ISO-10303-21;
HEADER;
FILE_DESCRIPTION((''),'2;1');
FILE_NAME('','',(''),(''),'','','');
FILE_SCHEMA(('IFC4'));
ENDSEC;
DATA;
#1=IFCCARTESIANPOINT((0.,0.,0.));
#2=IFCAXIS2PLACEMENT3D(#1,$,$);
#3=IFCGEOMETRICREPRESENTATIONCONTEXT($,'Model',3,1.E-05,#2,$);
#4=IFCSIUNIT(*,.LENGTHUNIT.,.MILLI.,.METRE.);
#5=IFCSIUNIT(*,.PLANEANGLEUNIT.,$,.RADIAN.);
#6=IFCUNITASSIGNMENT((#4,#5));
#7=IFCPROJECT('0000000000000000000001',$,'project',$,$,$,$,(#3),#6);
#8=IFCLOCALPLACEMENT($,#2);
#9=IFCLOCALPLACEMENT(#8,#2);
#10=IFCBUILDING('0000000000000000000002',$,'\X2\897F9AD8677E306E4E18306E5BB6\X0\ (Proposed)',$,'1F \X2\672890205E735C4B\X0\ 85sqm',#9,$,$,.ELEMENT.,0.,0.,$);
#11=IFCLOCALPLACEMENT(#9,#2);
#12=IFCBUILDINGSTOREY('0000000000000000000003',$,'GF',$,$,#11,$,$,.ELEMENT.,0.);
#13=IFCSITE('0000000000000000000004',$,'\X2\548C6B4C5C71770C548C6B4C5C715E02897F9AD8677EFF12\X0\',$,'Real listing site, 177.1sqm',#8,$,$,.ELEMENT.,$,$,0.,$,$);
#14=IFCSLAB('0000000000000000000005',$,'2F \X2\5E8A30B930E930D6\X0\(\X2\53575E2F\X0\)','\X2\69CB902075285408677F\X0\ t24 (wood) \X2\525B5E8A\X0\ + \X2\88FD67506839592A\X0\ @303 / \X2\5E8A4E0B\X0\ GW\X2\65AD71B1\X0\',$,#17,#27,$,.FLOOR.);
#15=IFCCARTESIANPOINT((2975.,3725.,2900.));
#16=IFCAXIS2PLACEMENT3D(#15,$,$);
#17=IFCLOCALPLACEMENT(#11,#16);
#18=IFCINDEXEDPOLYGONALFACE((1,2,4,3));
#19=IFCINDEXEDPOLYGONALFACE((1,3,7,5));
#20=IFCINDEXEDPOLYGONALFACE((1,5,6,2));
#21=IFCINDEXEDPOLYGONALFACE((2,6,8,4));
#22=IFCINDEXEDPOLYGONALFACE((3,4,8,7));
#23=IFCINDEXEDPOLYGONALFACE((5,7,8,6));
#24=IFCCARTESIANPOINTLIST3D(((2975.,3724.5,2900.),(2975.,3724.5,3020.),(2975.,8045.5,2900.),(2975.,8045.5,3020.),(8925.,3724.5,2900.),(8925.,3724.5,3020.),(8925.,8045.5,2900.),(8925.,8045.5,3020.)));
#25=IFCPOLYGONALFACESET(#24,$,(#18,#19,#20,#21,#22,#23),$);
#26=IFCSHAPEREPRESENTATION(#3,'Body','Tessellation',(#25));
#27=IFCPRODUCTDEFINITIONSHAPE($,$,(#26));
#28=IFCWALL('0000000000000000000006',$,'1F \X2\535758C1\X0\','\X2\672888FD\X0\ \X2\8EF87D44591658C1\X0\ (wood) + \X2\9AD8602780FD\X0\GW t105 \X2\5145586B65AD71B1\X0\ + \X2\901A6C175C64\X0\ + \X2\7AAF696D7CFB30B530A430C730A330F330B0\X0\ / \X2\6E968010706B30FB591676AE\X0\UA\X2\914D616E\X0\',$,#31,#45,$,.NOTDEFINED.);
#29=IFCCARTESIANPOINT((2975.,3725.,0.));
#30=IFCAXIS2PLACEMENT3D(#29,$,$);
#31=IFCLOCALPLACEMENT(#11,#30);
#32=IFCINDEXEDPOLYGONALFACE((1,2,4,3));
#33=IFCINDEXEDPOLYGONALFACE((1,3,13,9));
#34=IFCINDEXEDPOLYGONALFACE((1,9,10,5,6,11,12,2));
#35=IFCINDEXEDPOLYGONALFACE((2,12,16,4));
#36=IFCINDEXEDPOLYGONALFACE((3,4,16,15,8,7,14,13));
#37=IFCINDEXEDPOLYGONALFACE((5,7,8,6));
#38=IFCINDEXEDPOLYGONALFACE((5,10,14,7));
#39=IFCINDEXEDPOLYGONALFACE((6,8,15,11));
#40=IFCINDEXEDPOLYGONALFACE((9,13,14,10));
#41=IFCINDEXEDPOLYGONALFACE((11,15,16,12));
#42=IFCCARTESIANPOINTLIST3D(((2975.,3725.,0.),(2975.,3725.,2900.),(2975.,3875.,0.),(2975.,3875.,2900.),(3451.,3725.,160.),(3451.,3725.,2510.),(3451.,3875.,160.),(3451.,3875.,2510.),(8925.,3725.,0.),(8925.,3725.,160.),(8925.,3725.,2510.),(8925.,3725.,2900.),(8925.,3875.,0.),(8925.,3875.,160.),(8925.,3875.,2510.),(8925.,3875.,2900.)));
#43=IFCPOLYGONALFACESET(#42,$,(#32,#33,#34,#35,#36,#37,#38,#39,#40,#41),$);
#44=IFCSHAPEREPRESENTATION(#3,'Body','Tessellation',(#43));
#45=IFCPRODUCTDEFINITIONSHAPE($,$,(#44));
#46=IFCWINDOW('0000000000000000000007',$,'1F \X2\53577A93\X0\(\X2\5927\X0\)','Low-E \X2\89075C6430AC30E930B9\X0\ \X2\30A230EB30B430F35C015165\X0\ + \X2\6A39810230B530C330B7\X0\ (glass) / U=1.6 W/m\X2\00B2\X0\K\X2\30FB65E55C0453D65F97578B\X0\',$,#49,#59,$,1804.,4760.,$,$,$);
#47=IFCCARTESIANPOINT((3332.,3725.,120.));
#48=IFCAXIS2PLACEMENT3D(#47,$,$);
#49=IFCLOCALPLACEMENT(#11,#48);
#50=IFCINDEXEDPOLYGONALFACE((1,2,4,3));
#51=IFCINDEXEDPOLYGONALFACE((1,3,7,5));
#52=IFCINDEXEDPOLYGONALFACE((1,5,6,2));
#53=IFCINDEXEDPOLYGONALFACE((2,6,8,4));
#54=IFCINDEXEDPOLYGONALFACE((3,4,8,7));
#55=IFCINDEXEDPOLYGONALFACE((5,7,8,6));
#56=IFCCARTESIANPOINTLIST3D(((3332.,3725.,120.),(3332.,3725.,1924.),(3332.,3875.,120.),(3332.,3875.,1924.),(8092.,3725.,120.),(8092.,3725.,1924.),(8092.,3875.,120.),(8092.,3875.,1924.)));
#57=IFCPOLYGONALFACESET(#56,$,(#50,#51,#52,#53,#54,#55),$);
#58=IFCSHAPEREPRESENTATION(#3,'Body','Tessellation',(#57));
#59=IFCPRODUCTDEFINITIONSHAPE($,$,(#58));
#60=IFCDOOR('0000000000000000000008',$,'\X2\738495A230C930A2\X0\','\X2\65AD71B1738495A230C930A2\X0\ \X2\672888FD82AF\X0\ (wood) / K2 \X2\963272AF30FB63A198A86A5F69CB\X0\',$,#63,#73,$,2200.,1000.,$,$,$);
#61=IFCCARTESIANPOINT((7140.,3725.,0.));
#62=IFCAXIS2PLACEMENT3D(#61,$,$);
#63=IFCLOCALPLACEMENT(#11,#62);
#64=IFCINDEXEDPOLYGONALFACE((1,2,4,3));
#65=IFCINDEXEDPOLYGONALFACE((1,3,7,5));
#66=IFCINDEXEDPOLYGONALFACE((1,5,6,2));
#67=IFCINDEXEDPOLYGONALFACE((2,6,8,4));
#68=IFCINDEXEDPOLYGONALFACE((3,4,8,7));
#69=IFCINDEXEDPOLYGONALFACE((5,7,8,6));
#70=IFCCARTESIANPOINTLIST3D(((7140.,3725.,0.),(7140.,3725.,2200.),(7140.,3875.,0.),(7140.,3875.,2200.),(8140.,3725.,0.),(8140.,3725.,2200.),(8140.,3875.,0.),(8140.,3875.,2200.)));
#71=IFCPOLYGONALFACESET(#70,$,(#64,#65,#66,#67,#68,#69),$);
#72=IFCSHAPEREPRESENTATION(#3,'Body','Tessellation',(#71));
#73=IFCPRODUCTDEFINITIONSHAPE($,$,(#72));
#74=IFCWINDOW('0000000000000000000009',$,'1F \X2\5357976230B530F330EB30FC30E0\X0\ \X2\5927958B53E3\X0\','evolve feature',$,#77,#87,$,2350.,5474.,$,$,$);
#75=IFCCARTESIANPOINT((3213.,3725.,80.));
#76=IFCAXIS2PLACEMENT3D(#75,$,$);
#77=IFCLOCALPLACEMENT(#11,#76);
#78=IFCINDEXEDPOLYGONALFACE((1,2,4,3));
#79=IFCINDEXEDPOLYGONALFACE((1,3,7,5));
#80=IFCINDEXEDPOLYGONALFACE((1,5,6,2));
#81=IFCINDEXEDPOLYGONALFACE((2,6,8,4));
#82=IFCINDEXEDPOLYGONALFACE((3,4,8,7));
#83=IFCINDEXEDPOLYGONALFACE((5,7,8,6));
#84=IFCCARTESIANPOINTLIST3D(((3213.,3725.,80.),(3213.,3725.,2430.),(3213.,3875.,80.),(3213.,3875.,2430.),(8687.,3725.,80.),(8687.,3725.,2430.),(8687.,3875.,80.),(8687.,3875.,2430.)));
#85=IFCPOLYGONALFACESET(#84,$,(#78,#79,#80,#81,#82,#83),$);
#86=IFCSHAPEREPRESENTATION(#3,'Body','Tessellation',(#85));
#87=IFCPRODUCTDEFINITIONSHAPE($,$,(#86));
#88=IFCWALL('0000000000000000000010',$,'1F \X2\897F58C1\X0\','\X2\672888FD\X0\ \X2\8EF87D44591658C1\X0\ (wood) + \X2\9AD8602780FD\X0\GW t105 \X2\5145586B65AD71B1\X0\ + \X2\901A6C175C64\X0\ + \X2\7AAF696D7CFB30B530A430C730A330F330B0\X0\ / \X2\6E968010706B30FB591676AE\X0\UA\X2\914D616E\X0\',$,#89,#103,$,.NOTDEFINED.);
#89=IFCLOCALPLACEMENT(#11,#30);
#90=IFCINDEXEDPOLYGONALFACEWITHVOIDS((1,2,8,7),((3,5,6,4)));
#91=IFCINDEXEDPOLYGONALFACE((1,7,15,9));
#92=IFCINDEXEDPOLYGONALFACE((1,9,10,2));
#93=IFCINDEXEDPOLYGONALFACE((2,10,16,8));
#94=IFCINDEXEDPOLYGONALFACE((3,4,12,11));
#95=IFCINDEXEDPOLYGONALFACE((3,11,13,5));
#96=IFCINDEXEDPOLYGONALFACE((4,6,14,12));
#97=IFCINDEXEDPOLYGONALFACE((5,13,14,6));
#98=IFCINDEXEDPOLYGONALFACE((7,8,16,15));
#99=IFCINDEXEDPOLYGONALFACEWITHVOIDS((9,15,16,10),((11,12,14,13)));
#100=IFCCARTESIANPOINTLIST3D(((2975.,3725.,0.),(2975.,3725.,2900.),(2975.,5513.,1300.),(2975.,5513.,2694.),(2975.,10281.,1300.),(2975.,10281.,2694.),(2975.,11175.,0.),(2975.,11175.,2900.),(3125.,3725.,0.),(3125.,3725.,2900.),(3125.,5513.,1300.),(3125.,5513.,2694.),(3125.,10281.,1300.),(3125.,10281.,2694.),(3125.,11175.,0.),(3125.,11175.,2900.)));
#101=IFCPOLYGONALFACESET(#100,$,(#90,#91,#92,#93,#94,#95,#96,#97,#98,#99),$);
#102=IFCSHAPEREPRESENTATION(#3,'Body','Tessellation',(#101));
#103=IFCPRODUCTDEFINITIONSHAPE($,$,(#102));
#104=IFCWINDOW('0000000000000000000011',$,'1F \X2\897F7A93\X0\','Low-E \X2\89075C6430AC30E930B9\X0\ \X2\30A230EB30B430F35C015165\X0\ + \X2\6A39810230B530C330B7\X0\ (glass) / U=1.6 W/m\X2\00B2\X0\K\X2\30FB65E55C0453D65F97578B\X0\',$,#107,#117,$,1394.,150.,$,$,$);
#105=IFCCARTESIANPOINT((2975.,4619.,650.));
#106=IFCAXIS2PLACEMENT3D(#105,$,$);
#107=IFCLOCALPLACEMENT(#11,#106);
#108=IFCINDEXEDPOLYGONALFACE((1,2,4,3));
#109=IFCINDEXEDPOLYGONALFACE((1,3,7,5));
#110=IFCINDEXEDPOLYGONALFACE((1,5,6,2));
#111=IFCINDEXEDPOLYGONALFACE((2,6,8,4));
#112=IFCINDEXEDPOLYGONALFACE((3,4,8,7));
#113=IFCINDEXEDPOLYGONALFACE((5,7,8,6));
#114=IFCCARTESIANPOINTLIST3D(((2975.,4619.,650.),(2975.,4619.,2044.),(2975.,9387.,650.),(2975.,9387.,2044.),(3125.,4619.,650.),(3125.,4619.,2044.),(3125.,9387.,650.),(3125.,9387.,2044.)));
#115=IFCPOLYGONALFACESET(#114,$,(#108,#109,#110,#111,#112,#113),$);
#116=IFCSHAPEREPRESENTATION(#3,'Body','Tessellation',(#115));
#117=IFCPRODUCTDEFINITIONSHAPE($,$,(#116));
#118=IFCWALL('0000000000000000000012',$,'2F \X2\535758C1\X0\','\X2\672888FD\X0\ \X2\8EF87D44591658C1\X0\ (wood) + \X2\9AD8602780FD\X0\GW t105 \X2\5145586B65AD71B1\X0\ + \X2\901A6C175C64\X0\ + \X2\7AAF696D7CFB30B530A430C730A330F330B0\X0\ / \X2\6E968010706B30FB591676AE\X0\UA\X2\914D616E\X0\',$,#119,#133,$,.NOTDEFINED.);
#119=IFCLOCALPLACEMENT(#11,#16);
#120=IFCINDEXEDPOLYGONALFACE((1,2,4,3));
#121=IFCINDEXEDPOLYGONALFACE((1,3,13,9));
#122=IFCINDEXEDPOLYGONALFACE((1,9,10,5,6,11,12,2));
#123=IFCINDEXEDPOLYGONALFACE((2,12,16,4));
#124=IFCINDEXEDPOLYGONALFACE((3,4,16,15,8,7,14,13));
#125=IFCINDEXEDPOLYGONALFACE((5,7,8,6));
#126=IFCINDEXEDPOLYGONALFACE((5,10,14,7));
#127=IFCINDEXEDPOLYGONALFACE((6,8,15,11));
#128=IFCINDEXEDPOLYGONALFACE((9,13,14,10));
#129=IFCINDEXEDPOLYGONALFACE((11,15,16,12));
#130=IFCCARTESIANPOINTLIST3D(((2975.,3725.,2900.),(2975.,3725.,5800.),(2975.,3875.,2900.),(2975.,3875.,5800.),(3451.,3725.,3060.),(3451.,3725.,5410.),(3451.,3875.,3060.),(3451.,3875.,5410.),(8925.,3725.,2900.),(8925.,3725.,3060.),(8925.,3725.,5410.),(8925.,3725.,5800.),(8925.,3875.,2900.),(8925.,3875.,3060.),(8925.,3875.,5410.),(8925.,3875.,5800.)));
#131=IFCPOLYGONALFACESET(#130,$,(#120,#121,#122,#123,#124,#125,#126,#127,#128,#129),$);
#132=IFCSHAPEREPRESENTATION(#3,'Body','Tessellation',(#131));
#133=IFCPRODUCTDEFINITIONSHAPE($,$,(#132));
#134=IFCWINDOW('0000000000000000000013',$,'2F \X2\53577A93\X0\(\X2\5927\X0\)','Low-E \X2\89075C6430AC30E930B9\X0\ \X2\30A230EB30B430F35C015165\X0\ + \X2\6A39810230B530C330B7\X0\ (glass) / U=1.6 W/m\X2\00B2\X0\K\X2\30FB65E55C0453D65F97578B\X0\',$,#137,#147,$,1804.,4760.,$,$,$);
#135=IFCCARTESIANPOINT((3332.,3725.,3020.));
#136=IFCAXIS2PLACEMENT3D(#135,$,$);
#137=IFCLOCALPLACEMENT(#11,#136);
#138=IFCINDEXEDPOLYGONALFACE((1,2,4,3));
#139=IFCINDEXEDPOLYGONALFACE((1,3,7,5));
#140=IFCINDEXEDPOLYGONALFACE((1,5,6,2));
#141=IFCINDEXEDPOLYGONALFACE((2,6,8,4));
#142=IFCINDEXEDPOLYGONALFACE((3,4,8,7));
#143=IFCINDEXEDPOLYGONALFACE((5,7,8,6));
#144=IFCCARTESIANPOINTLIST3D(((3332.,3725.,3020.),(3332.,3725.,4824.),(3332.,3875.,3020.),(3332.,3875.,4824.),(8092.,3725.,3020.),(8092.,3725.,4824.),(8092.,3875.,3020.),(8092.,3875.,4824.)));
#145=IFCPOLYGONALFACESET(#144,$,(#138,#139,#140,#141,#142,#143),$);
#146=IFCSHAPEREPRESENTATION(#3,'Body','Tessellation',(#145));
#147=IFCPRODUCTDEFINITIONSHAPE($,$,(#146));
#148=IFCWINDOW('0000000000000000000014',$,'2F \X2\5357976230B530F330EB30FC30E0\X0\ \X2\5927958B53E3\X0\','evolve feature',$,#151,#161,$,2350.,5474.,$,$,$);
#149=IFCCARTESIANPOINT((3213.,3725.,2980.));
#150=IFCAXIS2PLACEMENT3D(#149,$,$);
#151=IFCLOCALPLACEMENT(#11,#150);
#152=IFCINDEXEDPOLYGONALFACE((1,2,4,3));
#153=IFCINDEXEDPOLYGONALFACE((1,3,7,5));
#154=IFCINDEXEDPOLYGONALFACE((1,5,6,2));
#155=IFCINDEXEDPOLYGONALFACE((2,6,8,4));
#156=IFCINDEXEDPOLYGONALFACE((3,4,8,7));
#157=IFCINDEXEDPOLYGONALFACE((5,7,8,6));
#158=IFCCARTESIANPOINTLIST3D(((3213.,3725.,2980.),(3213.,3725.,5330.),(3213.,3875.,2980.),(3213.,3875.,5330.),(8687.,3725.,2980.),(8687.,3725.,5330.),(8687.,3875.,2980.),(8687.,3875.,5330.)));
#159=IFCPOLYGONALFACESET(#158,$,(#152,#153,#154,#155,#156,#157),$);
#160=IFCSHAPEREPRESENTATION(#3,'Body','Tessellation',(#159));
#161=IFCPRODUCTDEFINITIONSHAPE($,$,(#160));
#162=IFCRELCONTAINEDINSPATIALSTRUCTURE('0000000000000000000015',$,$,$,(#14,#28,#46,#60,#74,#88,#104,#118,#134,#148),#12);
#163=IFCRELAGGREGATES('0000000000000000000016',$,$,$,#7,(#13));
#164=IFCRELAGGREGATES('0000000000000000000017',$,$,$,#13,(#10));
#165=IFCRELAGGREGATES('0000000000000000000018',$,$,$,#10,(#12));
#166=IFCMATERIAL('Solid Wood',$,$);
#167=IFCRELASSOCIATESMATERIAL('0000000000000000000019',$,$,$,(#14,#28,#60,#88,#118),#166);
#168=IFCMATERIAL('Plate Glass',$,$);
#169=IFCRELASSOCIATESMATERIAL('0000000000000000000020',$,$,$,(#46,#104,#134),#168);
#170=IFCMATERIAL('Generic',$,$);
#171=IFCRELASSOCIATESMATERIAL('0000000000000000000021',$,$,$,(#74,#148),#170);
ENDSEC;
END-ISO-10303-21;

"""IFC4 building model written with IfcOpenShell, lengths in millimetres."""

from ifc_helpers import new_model, si_unit, frame, frame_2d, origin, place, context, project, spatial, rectangle, extrude, material, element, fill, save


model = new_model("IFC4")

# Units and contexts
model_context = context("Model", 3, precision=1e-05, world=origin())
ifc_project = project(units=[si_unit("LENGTHUNIT", "METRE", prefix="MILLI"), si_unit("PLANEANGLEUNIT", "RADIAN")], contexts=[model_context])

# Site, building, storey
site_placement = place(None, origin())
site = spatial("IfcSite", under=ifc_project, at=site_placement, Name="和歌山県和歌山市西高松２", ObjectType="Real listing site, 177.1sqm", CompositionType="ELEMENT", RefElevation=0.0)
building_placement = place(site_placement, origin())
building = spatial("IfcBuilding", under=site, at=building_placement, Name="西高松の丘の家 (Proposed)", ObjectType="1F 木造平屋 85sqm", CompositionType="ELEMENT", ElevationOfRefHeight=0.0, ElevationOfTerrain=0.0)
storey_placement = place(building_placement, origin())
storey = spatial("IfcBuildingStorey", under=building, at=storey_placement, Name="GF", CompositionType="ELEMENT", Elevation=0.0)

# Slab
ifc_material_1 = material(Name="Solid Wood")
slab_1_placement = place(storey_placement, frame((2975.0, 3725.0, 2900.0)))
element("IfcSlab", 1, at=slab_1_placement, inside=storey, material=ifc_material_1, Name="2F 床スラブ(南帯)", Description="構造用合板 t24 (wood) 剛床 + 製材根太 @303 / 床下 GW断熱", PredefinedType="FLOOR", context=model_context, shape_type="SweptSolid", body=[
    extrude(rectangle(XDim=5950.0, YDim=4321.0, at=frame_2d((2975.0, 2160.0))), frame((2975.0, 3725.0, 2900.0)), (0.0, 0.0, 1.0), 120.0),
])
ifc_material_2 = material(Name="Generic")

# Wall, openings, windows, door
wall_1_placement = place(storey_placement, frame((2975.0, 3725.0, 0.0)))
wall_1 = element("IfcWall", 2, at=wall_1_placement, inside=storey, material=ifc_material_1, Name="1F 南壁", Description="木製 軸組外壁 (wood) + 高性能GW t105 充填断熱 + 通気層 + 窯業系サイディング / 準耐火・外皮UA配慮", PredefinedType="NOTDEFINED", context=model_context, shape_type="SweptSolid", body=[
    extrude(rectangle(XDim=5950.0, YDim=150.0, at=frame_2d((2975.0, 75.0))), frame((2975.0, 3725.0, 0.0)), (0.0, 0.0, 1.0), 2900.0),
])
opening_1_placement = place(storey_placement, frame((3332.0, 3725.0, 120.0)))
opening_1 = element("IfcOpeningElement", 3, at=opening_1_placement, cuts=wall_1, PredefinedType="NOTDEFINED", context=model_context, shape_type="SweptSolid", body=[
    extrude(rectangle(XDim=4760.0, YDim=150.0, at=frame_2d((2380.0, 75.0))), frame((3332.0, 3725.0, 120.0)), (0.0, 0.0, 1.0), 1804.0),
])
opening_2_placement = place(storey_placement, frame((7140.0, 3725.0, 0.0)))
opening_2 = element("IfcOpeningElement", 4, at=opening_2_placement, cuts=wall_1, PredefinedType="NOTDEFINED", context=model_context, shape_type="SweptSolid", body=[
    extrude(rectangle(XDim=1000.0, YDim=150.0, at=frame_2d((500.0, 75.0))), frame((7140.0, 3725.0, 0.0)), (0.0, 0.0, 1.0), 2200.0),
])
opening_3_placement = place(storey_placement, frame((3213.0, 3725.0, 80.0)))
opening_3 = element("IfcOpeningElement", 5, at=opening_3_placement, cuts=wall_1, PredefinedType="NOTDEFINED", context=model_context, shape_type="SweptSolid", body=[
    extrude(rectangle(XDim=5474.0, YDim=150.0, at=frame_2d((2737.0, 75.0))), frame((3213.0, 3725.0, 80.0)), (0.0, 0.0, 1.0), 2350.0),
])
ifc_material_3 = material(Name="Plate Glass")
window_1_placement = place(storey_placement, frame((3332.0, 3725.0, 120.0)))
window_1 = element("IfcWindow", 6, at=window_1_placement, inside=storey, material=ifc_material_3, Name="1F 南窓(大)", Description="Low-E 複層ガラス アルゴン封入 + 樹脂サッシ (glass) / U=1.6 W/m²K・日射取得型", OverallHeight=1804.0, OverallWidth=4760.0, context=model_context, shape_type="SweptSolid", body=[
    extrude(rectangle(XDim=4760.0, YDim=150.0, at=frame_2d((2380.0, 75.0))), frame((3332.0, 3725.0, 120.0)), (0.0, 0.0, 1.0), 1804.0),
])
fill(opening_1, window_1)
door_placement = place(storey_placement, frame((7140.0, 3725.0, 0.0)))
door = element("IfcDoor", 7, at=door_placement, inside=storey, material=ifc_material_1, Name="玄関ドア", Description="断熱玄関ドア 木製芯 (wood) / K2 防犯・採風機構", OverallHeight=2200.0, OverallWidth=1000.0, context=model_context, shape_type="SweptSolid", body=[
    extrude(rectangle(XDim=1000.0, YDim=150.0, at=frame_2d((500.0, 75.0))), frame((7140.0, 3725.0, 0.0)), (0.0, 0.0, 1.0), 2200.0),
])
fill(opening_2, door)
window_2_placement = place(storey_placement, frame((3213.0, 3725.0, 80.0)))
window_2 = element("IfcWindow", 8, at=window_2_placement, inside=storey, material=ifc_material_2, Name="1F 南面サンルーム 大開口", Description="evolve feature", OverallHeight=2350.0, OverallWidth=5474.0, context=model_context, shape_type="SweptSolid", body=[
    extrude(rectangle(XDim=5474.0, YDim=150.0, at=frame_2d((2737.0, 75.0))), frame((3213.0, 3725.0, 80.0)), (0.0, 0.0, 1.0), 2350.0),
])
fill(opening_3, window_2)

# Wall, opening, window
wall_2_placement = place(storey_placement, frame((2975.0, 3725.0, 0.0)))
wall_2 = element("IfcWall", 9, at=wall_2_placement, inside=storey, material=ifc_material_1, Name="1F 西壁", Description="木製 軸組外壁 (wood) + 高性能GW t105 充填断熱 + 通気層 + 窯業系サイディング / 準耐火・外皮UA配慮", PredefinedType="NOTDEFINED", context=model_context, shape_type="SweptSolid", body=[
    extrude(rectangle(XDim=150.0, YDim=7450.0, at=frame_2d((75.0, 3725.0))), frame((2975.0, 3725.0, 0.0)), (0.0, 0.0, 1.0), 2900.0),
])
opening_4_placement = place(storey_placement, frame((2975.0, 4619.0, 650.0)))
opening_4 = element("IfcOpeningElement", 10, at=opening_4_placement, cuts=wall_2, PredefinedType="NOTDEFINED", context=model_context, shape_type="SweptSolid", body=[
    extrude(rectangle(XDim=150.0, YDim=4768.0, at=frame_2d((75.0, 2384.0))), frame((2975.0, 4619.0, 650.0)), (0.0, 0.0, 1.0), 1394.0),
])
window_3_placement = place(storey_placement, frame((2975.0, 4619.0, 650.0)))
window_3 = element("IfcWindow", 11, at=window_3_placement, inside=storey, material=ifc_material_3, Name="1F 西窓", Description="Low-E 複層ガラス アルゴン封入 + 樹脂サッシ (glass) / U=1.6 W/m²K・日射取得型", OverallHeight=1394.0, OverallWidth=150.0, context=model_context, shape_type="SweptSolid", body=[
    extrude(rectangle(XDim=150.0, YDim=4768.0, at=frame_2d((75.0, 2384.0))), frame((2975.0, 4619.0, 650.0)), (0.0, 0.0, 1.0), 1394.0),
])
fill(opening_4, window_3)

# Wall, openings, windows
wall_3_placement = place(storey_placement, frame((2975.0, 3725.0, 2900.0)))
wall_3 = element("IfcWall", 12, at=wall_3_placement, inside=storey, material=ifc_material_1, Name="2F 南壁", Description="木製 軸組外壁 (wood) + 高性能GW t105 充填断熱 + 通気層 + 窯業系サイディング / 準耐火・外皮UA配慮", PredefinedType="NOTDEFINED", context=model_context, shape_type="SweptSolid", body=[
    extrude(rectangle(XDim=5950.0, YDim=150.0, at=frame_2d((2975.0, 75.0))), frame((2975.0, 3725.0, 2900.0)), (0.0, 0.0, 1.0), 2900.0),
])
opening_5_placement = place(storey_placement, frame((3332.0, 3725.0, 3020.0)))
opening_5 = element("IfcOpeningElement", 13, at=opening_5_placement, cuts=wall_3, PredefinedType="NOTDEFINED", context=model_context, shape_type="SweptSolid", body=[
    extrude(rectangle(XDim=4760.0, YDim=150.0, at=frame_2d((2380.0, 75.0))), frame((3332.0, 3725.0, 3020.0)), (0.0, 0.0, 1.0), 1804.0),
])
opening_6_placement = place(storey_placement, frame((3213.0, 3725.0, 2980.0)))
opening_6 = element("IfcOpeningElement", 14, at=opening_6_placement, cuts=wall_3, PredefinedType="NOTDEFINED", context=model_context, shape_type="SweptSolid", body=[
    extrude(rectangle(XDim=5474.0, YDim=150.0, at=frame_2d((2737.0, 75.0))), frame((3213.0, 3725.0, 2980.0)), (0.0, 0.0, 1.0), 2350.0),
])
window_4_placement = place(storey_placement, frame((3332.0, 3725.0, 3020.0)))
window_4 = element("IfcWindow", 15, at=window_4_placement, inside=storey, material=ifc_material_3, Name="2F 南窓(大)", Description="Low-E 複層ガラス アルゴン封入 + 樹脂サッシ (glass) / U=1.6 W/m²K・日射取得型", OverallHeight=1804.0, OverallWidth=4760.0, context=model_context, shape_type="SweptSolid", body=[
    extrude(rectangle(XDim=4760.0, YDim=150.0, at=frame_2d((2380.0, 75.0))), frame((3332.0, 3725.0, 3020.0)), (0.0, 0.0, 1.0), 1804.0),
])
fill(opening_5, window_4)
window_5_placement = place(storey_placement, frame((3213.0, 3725.0, 2980.0)))
window_5 = element("IfcWindow", 16, at=window_5_placement, inside=storey, material=ifc_material_2, Name="2F 南面サンルーム 大開口", Description="evolve feature", OverallHeight=2350.0, OverallWidth=5474.0, context=model_context, shape_type="SweptSolid", body=[
    extrude(rectangle(XDim=5474.0, YDim=150.0, at=frame_2d((2737.0, 75.0))), frame((3213.0, 3725.0, 2980.0)), (0.0, 0.0, 1.0), 2350.0),
])
fill(opening_6, window_5)

save(model, "model.ifc")
